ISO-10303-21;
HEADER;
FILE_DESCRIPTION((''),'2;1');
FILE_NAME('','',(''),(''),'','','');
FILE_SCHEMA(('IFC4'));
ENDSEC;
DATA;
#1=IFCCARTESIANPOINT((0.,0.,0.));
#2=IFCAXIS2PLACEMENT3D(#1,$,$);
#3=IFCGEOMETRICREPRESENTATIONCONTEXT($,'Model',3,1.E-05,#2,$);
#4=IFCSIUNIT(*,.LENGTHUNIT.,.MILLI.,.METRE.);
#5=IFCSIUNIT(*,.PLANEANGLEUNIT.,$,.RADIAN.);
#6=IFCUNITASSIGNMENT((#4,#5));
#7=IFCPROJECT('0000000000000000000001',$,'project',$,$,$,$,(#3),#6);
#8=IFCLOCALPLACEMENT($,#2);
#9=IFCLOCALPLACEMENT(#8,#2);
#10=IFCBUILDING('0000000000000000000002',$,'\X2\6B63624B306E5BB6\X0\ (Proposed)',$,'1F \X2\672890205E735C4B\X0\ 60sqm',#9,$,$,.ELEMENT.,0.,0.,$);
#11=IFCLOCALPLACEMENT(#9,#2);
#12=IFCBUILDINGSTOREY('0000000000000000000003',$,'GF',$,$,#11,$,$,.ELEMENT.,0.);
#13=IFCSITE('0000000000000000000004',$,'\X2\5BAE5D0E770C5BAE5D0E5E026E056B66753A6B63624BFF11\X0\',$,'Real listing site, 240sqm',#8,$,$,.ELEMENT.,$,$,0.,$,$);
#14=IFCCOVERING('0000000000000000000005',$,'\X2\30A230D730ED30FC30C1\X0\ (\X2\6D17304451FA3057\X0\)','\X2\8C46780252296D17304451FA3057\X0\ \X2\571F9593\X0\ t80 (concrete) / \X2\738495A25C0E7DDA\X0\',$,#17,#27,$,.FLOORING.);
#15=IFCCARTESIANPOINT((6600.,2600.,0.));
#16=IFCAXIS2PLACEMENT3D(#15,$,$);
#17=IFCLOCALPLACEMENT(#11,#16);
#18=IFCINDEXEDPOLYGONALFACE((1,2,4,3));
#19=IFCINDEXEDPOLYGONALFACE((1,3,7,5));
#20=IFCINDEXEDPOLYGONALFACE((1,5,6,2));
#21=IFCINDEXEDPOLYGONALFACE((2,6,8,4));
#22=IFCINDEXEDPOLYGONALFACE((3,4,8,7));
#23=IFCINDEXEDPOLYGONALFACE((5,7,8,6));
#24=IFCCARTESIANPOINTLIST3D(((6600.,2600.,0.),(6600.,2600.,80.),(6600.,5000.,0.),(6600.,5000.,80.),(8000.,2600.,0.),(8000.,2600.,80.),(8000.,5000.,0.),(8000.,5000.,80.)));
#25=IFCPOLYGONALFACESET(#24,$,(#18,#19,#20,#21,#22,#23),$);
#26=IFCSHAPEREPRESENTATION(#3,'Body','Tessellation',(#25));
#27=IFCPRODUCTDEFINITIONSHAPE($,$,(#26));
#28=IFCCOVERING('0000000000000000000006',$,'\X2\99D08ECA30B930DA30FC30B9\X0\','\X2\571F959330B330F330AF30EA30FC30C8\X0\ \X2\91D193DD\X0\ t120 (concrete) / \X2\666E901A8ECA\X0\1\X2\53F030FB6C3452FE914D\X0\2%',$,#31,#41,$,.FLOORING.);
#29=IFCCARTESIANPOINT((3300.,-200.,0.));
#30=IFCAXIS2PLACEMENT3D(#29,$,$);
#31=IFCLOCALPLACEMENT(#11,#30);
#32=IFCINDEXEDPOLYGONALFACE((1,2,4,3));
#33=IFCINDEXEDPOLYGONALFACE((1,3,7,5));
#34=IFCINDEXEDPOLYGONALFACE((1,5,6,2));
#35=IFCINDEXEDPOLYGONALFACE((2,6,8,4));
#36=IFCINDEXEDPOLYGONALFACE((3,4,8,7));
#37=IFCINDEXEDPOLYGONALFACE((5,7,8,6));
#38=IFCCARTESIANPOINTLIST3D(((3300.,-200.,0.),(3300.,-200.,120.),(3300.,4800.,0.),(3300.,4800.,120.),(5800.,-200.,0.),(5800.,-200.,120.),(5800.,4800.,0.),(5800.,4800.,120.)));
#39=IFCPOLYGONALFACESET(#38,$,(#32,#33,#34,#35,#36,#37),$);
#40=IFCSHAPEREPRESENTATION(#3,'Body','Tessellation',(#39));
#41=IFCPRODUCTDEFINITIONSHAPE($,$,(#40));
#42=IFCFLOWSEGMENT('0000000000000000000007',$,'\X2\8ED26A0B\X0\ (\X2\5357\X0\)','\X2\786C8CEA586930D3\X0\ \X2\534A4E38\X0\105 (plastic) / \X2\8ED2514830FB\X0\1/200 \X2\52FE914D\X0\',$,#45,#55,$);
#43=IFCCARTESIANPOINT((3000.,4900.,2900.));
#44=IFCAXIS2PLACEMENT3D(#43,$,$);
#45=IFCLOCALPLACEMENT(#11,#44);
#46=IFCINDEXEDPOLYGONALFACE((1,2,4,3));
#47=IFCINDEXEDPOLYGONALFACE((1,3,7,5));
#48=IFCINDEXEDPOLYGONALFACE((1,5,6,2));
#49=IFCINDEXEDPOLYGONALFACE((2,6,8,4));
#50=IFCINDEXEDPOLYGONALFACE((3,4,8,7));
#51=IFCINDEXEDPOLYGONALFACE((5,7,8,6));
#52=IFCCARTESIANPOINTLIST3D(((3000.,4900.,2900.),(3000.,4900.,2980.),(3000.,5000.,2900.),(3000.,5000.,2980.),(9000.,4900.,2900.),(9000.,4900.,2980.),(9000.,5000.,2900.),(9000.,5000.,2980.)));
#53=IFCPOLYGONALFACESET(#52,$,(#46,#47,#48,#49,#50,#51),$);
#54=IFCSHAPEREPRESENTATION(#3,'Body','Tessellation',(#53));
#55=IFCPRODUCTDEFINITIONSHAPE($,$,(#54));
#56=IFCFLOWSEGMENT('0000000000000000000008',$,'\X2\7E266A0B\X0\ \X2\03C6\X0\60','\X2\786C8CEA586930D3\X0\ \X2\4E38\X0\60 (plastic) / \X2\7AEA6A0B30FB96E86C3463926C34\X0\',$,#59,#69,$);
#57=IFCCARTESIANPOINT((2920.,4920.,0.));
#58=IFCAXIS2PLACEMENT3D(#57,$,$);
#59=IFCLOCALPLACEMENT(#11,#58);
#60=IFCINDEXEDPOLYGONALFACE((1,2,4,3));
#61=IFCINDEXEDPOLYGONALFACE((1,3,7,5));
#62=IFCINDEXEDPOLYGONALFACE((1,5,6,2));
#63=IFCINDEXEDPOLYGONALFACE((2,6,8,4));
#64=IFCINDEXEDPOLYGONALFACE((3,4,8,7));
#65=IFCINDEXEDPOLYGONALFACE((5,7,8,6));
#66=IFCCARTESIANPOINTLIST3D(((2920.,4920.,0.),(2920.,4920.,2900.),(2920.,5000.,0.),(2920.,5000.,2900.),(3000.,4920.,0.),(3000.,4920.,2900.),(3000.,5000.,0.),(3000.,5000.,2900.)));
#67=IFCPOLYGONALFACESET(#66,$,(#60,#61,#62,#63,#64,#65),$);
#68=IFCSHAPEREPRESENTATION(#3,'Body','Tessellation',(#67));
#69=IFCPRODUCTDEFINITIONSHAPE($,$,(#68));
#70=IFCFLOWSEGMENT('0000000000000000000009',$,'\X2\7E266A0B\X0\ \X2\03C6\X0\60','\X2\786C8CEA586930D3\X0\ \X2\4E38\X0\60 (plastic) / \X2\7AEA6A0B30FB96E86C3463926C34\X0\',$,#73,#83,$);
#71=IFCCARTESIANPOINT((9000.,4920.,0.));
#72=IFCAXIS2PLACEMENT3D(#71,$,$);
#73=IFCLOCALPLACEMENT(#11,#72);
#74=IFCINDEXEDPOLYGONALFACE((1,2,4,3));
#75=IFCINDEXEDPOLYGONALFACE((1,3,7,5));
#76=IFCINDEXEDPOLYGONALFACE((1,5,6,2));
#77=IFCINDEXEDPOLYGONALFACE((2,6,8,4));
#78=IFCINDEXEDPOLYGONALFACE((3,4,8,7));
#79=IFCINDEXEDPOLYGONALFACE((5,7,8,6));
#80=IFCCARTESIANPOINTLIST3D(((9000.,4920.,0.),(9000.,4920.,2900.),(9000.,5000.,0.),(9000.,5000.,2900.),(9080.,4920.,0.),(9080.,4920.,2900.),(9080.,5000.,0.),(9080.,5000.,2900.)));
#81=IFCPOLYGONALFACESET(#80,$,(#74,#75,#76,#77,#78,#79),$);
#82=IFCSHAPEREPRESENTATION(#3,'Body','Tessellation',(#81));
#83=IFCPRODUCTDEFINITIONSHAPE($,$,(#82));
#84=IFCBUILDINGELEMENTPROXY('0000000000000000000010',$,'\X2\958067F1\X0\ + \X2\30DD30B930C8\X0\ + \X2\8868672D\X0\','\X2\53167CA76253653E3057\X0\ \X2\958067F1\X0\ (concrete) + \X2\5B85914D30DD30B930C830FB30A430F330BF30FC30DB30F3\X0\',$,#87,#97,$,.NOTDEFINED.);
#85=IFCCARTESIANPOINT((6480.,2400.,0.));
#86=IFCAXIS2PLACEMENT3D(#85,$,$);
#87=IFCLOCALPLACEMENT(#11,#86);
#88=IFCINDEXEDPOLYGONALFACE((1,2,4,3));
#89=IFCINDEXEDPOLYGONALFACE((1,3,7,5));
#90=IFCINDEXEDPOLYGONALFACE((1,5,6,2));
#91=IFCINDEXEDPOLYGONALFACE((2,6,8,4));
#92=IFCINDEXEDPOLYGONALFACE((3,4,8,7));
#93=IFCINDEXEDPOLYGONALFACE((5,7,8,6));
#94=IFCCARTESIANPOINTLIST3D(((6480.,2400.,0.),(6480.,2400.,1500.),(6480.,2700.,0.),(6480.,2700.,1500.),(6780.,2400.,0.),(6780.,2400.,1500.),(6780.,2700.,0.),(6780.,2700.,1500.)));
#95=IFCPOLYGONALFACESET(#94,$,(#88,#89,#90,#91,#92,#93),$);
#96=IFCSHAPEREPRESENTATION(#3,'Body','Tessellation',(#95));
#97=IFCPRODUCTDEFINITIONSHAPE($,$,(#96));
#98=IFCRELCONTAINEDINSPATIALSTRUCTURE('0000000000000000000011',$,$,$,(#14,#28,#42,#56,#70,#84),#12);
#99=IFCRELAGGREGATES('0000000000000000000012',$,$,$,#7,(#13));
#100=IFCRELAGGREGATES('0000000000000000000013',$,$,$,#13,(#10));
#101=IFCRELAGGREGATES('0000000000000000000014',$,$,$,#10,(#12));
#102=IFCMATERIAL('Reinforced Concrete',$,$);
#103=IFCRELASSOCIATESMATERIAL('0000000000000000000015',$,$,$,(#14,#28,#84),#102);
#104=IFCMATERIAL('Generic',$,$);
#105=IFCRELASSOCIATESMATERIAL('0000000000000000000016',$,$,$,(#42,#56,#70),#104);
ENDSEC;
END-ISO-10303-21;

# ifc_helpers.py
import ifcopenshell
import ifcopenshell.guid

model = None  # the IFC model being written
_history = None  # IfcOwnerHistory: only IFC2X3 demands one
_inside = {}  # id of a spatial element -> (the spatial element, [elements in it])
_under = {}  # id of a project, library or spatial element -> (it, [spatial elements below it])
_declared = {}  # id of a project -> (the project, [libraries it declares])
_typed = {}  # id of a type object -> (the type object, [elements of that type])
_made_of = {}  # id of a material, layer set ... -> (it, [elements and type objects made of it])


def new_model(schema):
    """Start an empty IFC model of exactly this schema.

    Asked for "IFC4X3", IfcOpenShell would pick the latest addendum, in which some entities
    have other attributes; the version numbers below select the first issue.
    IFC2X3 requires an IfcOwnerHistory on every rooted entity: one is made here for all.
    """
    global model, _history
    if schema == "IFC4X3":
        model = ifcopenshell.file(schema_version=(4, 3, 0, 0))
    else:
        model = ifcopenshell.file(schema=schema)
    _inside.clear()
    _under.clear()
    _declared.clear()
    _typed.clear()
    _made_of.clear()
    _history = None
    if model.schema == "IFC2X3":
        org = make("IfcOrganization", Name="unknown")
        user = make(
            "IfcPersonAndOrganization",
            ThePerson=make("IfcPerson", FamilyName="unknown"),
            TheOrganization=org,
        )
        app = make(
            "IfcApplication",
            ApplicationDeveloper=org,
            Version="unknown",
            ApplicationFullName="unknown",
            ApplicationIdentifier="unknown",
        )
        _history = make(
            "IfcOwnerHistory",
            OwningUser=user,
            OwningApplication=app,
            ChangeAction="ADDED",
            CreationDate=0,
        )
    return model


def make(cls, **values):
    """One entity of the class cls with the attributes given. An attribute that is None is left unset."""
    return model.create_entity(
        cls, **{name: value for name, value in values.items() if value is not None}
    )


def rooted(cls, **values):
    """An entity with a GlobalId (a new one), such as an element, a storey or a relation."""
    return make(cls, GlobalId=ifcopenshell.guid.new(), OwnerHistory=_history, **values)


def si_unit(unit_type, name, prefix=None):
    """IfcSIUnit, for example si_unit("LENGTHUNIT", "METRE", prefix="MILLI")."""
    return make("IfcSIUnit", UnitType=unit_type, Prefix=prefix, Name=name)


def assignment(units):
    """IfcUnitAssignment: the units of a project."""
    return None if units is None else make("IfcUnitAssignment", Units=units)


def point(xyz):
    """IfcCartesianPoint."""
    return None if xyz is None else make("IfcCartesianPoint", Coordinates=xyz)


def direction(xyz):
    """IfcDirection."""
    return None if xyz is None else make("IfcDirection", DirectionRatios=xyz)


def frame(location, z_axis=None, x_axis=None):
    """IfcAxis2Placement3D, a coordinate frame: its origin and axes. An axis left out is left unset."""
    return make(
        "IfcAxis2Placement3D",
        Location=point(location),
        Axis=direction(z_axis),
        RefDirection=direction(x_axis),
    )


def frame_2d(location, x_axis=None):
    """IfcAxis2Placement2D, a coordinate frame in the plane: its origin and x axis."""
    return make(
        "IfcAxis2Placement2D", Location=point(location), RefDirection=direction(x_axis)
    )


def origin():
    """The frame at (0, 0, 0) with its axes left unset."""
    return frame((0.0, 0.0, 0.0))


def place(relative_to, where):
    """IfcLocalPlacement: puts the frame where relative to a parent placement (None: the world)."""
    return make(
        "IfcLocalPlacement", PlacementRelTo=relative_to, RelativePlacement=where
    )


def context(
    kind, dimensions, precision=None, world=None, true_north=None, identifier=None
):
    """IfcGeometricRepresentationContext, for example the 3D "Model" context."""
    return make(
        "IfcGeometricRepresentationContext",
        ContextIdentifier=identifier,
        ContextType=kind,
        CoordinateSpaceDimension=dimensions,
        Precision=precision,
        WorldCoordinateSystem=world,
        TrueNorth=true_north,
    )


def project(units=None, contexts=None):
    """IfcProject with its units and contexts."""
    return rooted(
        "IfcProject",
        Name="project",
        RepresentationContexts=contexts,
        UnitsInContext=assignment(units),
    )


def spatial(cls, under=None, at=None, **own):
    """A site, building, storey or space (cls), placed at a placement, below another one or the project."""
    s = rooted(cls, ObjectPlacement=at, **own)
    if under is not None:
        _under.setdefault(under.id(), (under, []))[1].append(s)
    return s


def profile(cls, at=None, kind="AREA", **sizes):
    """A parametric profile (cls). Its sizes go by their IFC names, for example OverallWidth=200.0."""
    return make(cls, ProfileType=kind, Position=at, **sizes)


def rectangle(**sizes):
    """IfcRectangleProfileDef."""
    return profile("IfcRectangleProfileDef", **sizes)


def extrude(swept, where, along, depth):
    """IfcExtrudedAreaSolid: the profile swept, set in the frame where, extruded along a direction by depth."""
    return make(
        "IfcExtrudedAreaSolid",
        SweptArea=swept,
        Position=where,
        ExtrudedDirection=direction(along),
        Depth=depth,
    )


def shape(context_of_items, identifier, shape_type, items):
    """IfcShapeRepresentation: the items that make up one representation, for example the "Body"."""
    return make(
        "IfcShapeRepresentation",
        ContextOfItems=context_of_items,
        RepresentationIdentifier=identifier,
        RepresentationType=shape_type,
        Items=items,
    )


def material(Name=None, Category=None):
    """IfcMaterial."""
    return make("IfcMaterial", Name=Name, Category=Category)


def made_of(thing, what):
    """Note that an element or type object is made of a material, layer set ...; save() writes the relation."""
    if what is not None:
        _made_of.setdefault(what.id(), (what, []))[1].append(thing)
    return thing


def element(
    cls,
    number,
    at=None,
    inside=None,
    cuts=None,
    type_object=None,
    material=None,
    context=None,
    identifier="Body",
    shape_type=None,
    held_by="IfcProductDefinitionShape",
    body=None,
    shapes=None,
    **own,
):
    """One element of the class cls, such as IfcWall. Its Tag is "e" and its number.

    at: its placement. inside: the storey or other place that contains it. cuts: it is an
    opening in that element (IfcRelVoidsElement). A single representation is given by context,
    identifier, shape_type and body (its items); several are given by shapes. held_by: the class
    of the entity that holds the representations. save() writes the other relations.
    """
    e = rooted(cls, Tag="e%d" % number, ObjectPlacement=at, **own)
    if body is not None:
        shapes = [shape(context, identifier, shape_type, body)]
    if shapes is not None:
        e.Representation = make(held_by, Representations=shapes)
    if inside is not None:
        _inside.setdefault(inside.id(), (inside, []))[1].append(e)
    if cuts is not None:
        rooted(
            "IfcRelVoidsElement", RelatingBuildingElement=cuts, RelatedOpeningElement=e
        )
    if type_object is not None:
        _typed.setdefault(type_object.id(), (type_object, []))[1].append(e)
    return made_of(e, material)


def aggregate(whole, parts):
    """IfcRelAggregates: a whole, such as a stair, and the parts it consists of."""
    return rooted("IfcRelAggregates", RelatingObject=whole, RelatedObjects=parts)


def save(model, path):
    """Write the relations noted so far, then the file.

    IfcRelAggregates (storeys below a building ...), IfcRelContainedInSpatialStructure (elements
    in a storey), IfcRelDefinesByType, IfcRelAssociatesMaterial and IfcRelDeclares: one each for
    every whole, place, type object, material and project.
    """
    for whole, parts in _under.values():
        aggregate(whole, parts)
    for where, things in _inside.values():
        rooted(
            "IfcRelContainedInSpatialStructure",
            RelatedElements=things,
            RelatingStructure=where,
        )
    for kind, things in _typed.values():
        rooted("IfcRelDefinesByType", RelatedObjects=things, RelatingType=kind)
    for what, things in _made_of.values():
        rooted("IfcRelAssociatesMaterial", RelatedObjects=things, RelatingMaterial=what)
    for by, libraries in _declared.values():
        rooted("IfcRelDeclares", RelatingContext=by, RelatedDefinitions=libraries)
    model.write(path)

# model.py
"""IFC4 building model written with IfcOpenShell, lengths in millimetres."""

from ifc_helpers import new_model, si_unit, frame, frame_2d, origin, place, context, project, spatial, rectangle, extrude, material, element, save


model = new_model("IFC4")

# Units and contexts
model_context = context("Model", 3, precision=1e-05, world=origin())
ifc_project = project(units=[si_unit("LENGTHUNIT", "METRE", prefix="MILLI"), si_unit("PLANEANGLEUNIT", "RADIAN")], contexts=[model_context])

# Site, building, storey
site_placement = place(None, origin())
site = spatial("IfcSite", under=ifc_project, at=site_placement, Name="宮崎県宮崎市清武町正手１", ObjectType="Real listing site, 240sqm", CompositionType="ELEMENT", RefElevation=0.0)
building_placement = place(site_placement, origin())
building = spatial("IfcBuilding", under=site, at=building_placement, Name="正手の家 (Proposed)", ObjectType="1F 木造平屋 60sqm", CompositionType="ELEMENT", ElevationOfRefHeight=0.0, ElevationOfTerrain=0.0)
storey_placement = place(building_placement, origin())
storey = spatial("IfcBuildingStorey", under=building, at=storey_placement, Name="GF", CompositionType="ELEMENT", Elevation=0.0)

# Shared definitions
ifc_material_1 = material(Name="Reinforced Concrete")

# Coverings
ifc_material_2 = material(Name="Generic")
covering_1_placement = place(storey_placement, frame((6600.0, 2600.0, 0.0)))
element("IfcCovering", 1, at=covering_1_placement, inside=storey, material=ifc_material_1, Name="アプローチ (洗い出し)", Description="豆砂利洗い出し 土間 t80 (concrete) / 玄関導線", PredefinedType="FLOORING", context=model_context, shape_type="SweptSolid", body=[
    extrude(rectangle(XDim=1400.0, YDim=2400.0, at=frame_2d((700.0, 1200.0))), frame((6600.0, 2600.0, 0.0)), (0.0, 0.0, 1.0), 80.0),
])
covering_2_placement = place(storey_placement, frame((3300.0, -200.0, 0.0)))
element("IfcCovering", 2, at=covering_2_placement, inside=storey, material=ifc_material_1, Name="駐車スペース", Description="土間コンクリート 金鏝 t120 (concrete) / 普通車1台・水勾配2%", PredefinedType="FLOORING", context=model_context, shape_type="SweptSolid", body=[
    extrude(rectangle(XDim=2500.0, YDim=5000.0, at=frame_2d((1250.0, 2500.0))), frame((3300.0, -200.0, 0.0)), (0.0, 0.0, 1.0), 120.0),
])

# Flow segments
flow_segment_1_placement = place(storey_placement, frame((3000.0, 4900.0, 2900.0)))
element("IfcFlowSegment", 3, at=flow_segment_1_placement, inside=storey, material=ifc_material_2, Name="軒樋 (南)", Description="硬質塩ビ 半丸105 (plastic) / 軒先・1/200 勾配", context=model_context, shape_type="SweptSolid", body=[
    extrude(rectangle(XDim=6000.0, YDim=100.0, at=frame_2d((3000.0, 50.0))), frame((3000.0, 4900.0, 2900.0)), (0.0, 0.0, 1.0), 80.0),
])
flow_segment_2_placement = place(storey_placement, frame((2920.0, 4920.0, 0.0)))
element("IfcFlowSegment", 4, at=flow_segment_2_placement, inside=storey, material=ifc_material_2, Name="縦樋 φ60", Description="硬質塩ビ 丸60 (plastic) / 竪樋・雨水排水", context=model_context, shape_type="SweptSolid", body=[
    extrude(rectangle(XDim=80.0, YDim=80.0, at=frame_2d((40.0, 40.0))), frame((2920.0, 4920.0, 0.0)), (0.0, 0.0, 1.0), 2900.0),
])
flow_segment_3_placement = place(storey_placement, frame((9000.0, 4920.0, 0.0)))
element("IfcFlowSegment", 5, at=flow_segment_3_placement, inside=storey, material=ifc_material_2, Name="縦樋 φ60", Description="硬質塩ビ 丸60 (plastic) / 竪樋・雨水排水", context=model_context, shape_type="SweptSolid", body=[
    extrude(rectangle(XDim=80.0, YDim=80.0, at=frame_2d((40.0, 40.0))), frame((9000.0, 4920.0, 0.0)), (0.0, 0.0, 1.0), 2900.0),
])

# Building element proxy
proxy_placement = place(storey_placement, frame((6480.0, 2400.0, 0.0)))
element("IfcBuildingElementProxy", 6, at=proxy_placement, inside=storey, material=ifc_material_1, Name="門柱 + ポスト + 表札", Description="化粧打放し 門柱 (concrete) + 宅配ポスト・インターホン", PredefinedType="NOTDEFINED", context=model_context, shape_type="SweptSolid", body=[
    extrude(rectangle(XDim=300.0, YDim=300.0, at=frame_2d((150.0, 150.0))), frame((6480.0, 2400.0, 0.0)), (0.0, 0.0, 1.0), 1500.0),
])

save(model, "model.ifc")
